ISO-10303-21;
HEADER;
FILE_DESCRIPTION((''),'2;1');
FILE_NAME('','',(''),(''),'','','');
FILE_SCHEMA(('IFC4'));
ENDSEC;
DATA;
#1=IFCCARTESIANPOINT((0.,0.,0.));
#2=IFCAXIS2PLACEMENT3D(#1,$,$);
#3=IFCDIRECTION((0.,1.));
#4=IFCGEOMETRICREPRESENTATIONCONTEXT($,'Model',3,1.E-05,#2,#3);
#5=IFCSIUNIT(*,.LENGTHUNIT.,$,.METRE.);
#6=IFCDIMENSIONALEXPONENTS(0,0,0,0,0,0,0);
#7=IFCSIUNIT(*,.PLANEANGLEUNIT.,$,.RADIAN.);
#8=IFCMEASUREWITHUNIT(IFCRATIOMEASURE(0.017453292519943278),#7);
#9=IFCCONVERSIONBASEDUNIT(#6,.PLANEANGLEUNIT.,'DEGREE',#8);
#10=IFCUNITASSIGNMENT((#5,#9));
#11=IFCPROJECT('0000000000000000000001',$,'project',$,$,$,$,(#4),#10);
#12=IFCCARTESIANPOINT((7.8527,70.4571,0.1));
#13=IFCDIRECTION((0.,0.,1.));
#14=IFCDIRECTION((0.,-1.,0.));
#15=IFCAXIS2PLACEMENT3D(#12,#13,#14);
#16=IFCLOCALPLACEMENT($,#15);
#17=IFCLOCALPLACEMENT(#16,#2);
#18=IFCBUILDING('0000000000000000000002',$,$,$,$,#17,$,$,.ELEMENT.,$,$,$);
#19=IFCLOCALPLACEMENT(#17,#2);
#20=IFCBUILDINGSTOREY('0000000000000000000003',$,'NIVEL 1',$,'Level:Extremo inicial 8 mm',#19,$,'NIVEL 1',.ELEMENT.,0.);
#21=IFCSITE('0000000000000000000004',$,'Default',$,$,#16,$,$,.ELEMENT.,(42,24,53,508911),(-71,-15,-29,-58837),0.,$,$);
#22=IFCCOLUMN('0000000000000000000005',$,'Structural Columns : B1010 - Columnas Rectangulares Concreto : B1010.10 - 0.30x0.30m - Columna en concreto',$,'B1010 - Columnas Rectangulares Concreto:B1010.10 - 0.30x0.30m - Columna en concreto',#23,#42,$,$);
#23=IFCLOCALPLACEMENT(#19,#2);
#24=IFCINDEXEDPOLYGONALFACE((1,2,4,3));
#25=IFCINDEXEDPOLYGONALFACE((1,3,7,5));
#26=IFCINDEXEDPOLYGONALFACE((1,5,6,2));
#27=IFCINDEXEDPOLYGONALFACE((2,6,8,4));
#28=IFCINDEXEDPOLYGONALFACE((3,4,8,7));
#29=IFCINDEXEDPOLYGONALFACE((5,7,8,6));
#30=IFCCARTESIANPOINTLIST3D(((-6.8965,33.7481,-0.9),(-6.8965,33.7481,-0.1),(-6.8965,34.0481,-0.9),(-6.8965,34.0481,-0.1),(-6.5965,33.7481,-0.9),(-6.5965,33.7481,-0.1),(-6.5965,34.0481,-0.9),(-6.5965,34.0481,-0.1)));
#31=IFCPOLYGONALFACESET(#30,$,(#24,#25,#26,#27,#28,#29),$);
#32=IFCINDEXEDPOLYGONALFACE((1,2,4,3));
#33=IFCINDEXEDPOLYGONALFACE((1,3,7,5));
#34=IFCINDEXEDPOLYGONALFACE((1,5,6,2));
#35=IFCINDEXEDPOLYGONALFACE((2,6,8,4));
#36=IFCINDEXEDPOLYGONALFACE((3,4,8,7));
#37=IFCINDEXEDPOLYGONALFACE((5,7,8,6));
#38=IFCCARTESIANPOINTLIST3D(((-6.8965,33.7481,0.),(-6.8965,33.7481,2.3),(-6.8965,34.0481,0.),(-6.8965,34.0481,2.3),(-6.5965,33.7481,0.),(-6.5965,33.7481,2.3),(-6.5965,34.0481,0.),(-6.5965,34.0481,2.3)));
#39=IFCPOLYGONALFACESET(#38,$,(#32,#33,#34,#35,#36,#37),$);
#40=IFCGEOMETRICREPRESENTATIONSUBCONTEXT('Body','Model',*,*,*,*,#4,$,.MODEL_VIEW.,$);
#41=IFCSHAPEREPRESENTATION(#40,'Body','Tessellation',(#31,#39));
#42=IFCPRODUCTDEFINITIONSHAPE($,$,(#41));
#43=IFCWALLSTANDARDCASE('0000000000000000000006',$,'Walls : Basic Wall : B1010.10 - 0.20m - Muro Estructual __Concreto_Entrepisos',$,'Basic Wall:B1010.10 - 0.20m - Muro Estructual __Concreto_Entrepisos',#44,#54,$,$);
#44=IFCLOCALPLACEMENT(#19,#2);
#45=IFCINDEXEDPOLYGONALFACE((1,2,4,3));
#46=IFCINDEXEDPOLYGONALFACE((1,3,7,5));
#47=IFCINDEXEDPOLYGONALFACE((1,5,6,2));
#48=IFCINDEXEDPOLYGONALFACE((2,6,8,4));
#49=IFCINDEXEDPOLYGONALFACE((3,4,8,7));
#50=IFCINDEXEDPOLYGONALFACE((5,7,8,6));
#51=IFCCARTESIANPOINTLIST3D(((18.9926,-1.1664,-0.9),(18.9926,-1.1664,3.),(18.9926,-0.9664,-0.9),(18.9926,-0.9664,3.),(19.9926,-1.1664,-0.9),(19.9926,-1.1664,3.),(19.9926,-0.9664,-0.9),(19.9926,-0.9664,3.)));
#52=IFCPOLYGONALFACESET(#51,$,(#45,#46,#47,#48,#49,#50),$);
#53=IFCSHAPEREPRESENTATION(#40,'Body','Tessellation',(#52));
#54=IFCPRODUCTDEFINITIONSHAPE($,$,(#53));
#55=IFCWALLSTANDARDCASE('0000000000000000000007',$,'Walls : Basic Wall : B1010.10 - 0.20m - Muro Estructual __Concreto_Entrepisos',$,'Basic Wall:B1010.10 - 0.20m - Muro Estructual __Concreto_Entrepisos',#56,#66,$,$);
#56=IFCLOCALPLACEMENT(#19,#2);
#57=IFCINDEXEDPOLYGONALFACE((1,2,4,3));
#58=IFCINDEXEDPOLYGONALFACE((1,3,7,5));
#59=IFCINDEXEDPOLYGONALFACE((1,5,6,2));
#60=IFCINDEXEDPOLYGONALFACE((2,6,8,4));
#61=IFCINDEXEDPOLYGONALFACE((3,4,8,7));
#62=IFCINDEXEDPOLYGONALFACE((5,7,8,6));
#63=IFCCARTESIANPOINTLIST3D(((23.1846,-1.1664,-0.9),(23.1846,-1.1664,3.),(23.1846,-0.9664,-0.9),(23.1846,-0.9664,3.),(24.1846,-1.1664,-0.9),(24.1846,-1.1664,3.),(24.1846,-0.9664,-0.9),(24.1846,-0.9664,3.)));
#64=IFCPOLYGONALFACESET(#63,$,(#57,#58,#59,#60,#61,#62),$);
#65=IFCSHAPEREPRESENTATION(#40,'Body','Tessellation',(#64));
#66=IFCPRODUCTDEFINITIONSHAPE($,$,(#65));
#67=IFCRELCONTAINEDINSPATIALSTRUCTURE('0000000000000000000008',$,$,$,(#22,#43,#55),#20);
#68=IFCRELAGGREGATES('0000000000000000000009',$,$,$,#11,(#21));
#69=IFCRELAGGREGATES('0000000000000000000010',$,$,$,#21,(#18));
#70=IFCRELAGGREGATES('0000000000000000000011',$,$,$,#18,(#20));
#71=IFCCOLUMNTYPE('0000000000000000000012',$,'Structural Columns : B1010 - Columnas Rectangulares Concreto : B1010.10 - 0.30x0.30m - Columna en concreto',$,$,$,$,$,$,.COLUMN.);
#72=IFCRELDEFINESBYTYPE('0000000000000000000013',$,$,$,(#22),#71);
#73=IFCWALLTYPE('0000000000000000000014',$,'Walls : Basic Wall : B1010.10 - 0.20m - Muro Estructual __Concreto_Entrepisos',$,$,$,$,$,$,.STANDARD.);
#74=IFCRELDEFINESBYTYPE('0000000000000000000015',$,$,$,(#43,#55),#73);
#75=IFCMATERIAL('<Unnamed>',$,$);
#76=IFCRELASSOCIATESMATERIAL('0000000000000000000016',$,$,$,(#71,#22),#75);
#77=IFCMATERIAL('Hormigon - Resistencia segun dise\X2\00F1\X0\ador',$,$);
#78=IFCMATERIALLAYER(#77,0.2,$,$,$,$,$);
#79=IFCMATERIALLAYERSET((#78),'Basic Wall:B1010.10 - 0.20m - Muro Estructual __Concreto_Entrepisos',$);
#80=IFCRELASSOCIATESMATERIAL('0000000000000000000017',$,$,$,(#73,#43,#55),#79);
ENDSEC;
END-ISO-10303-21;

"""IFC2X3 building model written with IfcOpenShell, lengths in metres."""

from ifc_helpers import new_model, entity, si_unit, converted_unit, direction, frame, frame_2d, origin, place, context, subcontext, project, spatial, rectangle, extrude, source, transform, mapped, material, layer, layer_set, layer_usage, type_object, type_shapes, element, save


model = new_model("IFC2X3")

# Units and contexts
model_context = context("Model", 3, precision=1e-05, world=origin(), true_north=direction((0.0, 1.0)))
body_context = subcontext(model_context, "Body", "Model", "MODEL_VIEW")
ifc_project = project(units=[si_unit("LENGTHUNIT", "METRE"), converted_unit("PLANEANGLEUNIT", "DEGREE", entity("IfcRatioMeasure", 0.017453292519943278), si_unit("PLANEANGLEUNIT", "RADIAN"), dimensions=[0, 0, 0, 0, 0, 0, 0])], contexts=[model_context])

# Site, building, storey
site_placement = place(None, frame((7.8527, 70.4571, 0.1), z_axis=(0.0, 0.0, 1.0), x_axis=(0.0, -1.0, 0.0)))
site = spatial("IfcSite", under=ifc_project, at=site_placement, Name="Default", CompositionType="ELEMENT", RefLatitude=(42, 24, 53, 508911), RefLongitude=(-71, -15, -29, -58837), RefElevation=0.0)
building_placement = place(site_placement, origin())
building = spatial("IfcBuilding", under=site, at=building_placement, CompositionType="ELEMENT")
storey_placement = place(building_placement, origin())
storey = spatial("IfcBuildingStorey", under=building, at=storey_placement, Name="NIVEL 1", ObjectType="Level:Extremo inicial 8 mm", LongName="NIVEL 1", CompositionType="ELEMENT", Elevation=0.0)

# Column
ifc_material_1 = material(Name="<Unnamed>")
column_type_1 = type_object("IfcColumnType", Name="Structural Columns : B1010 - Columnas Rectangulares Concreto : B1010.10 - 0.30x0.30m - Columna en concreto", PredefinedType="COLUMN", material=ifc_material_1)
shared_shape_1 = source(origin(), body_context, "Body", "SweptSolid", [
    extrude(rectangle(XDim=0.3, YDim=0.3, at=frame_2d((0.0, 0.0), x_axis=(1.0, 0.0))), frame((-6.7465, 33.8981, -0.9), z_axis=(0.0, 0.0, 1.0), x_axis=(0.0, -1.0, 0.0)), (0.0, 0.0, 1.0), 0.8),
    extrude(rectangle(XDim=0.3, YDim=0.3, at=frame_2d((0.0, 0.0), x_axis=(1.0, 0.0))), frame((-6.7465, 33.8981, 0.0), z_axis=(0.0, 0.0, 1.0), x_axis=(0.0, -1.0, 0.0)), (0.0, 0.0, 1.0), 2.3),
])
type_shapes(column_type_1, [shared_shape_1])
column_1_placement = place(storey_placement, origin())
element("IfcColumn", 1, at=column_1_placement, inside=storey, type_object=column_type_1, material=ifc_material_1, Name="Structural Columns : B1010 - Columnas Rectangulares Concreto : B1010.10 - 0.30x0.30m - Columna en concreto", ObjectType="B1010 - Columnas Rectangulares Concreto:B1010.10 - 0.30x0.30m - Columna en concreto", context=body_context, shape_type="MappedRepresentation", body=[
    mapped(shared_shape_1, transform((0.0, 0.0, 0.0), scale=1.0)),
])

# Walls
ifc_material_2 = material(Name="Hormigon - Resistencia segun diseñador")
ifc_layer = layer(ifc_material_2, 0.2)
ifc_layer_set = layer_set([ifc_layer], Name="Basic Wall:B1010.10 - 0.20m - Muro Estructual __Concreto_Entrepisos")
ifc_layer_usage_1 = layer_usage(ifc_layer_set, "AXIS2", "NEGATIVE", 0.1)
wall_type = type_object("IfcWallType", Name="Walls : Basic Wall : B1010.10 - 0.20m - Muro Estructual __Concreto_Entrepisos", PredefinedType="STANDARD", material=ifc_layer_set)
wall_1_placement = place(storey_placement, frame((18.9926, -1.0664, -0.9)))
element("IfcWallStandardCase", 2, at=wall_1_placement, inside=storey, type_object=wall_type, material=ifc_layer_usage_1, Name="Walls : Basic Wall : B1010.10 - 0.20m - Muro Estructual __Concreto_Entrepisos", ObjectType="Basic Wall:B1010.10 - 0.20m - Muro Estructual __Concreto_Entrepisos", context=body_context, shape_type="SweptSolid", body=[
    extrude(rectangle(XDim=1.0, YDim=0.2, at=frame_2d((0.5, 0.0), x_axis=(-1.0, 0.0))), origin(), (0.0, 0.0, 1.0), 3.9),
])
ifc_layer_usage_2 = layer_usage(ifc_layer_set, "AXIS2", "NEGATIVE", 0.1)
wall_2_placement = place(storey_placement, frame((23.1846, -1.0664, -0.9)))
element("IfcWallStandardCase", 3, at=wall_2_placement, inside=storey, type_object=wall_type, material=ifc_layer_usage_2, Name="Walls : Basic Wall : B1010.10 - 0.20m - Muro Estructual __Concreto_Entrepisos", ObjectType="Basic Wall:B1010.10 - 0.20m - Muro Estructual __Concreto_Entrepisos", context=body_context, shape_type="SweptSolid", body=[
    extrude(rectangle(XDim=1.0, YDim=0.2, at=frame_2d((0.5, 0.0), x_axis=(-1.0, 0.0))), origin(), (0.0, 0.0, 1.0), 3.9),
])

save(model, "model.ifc")
